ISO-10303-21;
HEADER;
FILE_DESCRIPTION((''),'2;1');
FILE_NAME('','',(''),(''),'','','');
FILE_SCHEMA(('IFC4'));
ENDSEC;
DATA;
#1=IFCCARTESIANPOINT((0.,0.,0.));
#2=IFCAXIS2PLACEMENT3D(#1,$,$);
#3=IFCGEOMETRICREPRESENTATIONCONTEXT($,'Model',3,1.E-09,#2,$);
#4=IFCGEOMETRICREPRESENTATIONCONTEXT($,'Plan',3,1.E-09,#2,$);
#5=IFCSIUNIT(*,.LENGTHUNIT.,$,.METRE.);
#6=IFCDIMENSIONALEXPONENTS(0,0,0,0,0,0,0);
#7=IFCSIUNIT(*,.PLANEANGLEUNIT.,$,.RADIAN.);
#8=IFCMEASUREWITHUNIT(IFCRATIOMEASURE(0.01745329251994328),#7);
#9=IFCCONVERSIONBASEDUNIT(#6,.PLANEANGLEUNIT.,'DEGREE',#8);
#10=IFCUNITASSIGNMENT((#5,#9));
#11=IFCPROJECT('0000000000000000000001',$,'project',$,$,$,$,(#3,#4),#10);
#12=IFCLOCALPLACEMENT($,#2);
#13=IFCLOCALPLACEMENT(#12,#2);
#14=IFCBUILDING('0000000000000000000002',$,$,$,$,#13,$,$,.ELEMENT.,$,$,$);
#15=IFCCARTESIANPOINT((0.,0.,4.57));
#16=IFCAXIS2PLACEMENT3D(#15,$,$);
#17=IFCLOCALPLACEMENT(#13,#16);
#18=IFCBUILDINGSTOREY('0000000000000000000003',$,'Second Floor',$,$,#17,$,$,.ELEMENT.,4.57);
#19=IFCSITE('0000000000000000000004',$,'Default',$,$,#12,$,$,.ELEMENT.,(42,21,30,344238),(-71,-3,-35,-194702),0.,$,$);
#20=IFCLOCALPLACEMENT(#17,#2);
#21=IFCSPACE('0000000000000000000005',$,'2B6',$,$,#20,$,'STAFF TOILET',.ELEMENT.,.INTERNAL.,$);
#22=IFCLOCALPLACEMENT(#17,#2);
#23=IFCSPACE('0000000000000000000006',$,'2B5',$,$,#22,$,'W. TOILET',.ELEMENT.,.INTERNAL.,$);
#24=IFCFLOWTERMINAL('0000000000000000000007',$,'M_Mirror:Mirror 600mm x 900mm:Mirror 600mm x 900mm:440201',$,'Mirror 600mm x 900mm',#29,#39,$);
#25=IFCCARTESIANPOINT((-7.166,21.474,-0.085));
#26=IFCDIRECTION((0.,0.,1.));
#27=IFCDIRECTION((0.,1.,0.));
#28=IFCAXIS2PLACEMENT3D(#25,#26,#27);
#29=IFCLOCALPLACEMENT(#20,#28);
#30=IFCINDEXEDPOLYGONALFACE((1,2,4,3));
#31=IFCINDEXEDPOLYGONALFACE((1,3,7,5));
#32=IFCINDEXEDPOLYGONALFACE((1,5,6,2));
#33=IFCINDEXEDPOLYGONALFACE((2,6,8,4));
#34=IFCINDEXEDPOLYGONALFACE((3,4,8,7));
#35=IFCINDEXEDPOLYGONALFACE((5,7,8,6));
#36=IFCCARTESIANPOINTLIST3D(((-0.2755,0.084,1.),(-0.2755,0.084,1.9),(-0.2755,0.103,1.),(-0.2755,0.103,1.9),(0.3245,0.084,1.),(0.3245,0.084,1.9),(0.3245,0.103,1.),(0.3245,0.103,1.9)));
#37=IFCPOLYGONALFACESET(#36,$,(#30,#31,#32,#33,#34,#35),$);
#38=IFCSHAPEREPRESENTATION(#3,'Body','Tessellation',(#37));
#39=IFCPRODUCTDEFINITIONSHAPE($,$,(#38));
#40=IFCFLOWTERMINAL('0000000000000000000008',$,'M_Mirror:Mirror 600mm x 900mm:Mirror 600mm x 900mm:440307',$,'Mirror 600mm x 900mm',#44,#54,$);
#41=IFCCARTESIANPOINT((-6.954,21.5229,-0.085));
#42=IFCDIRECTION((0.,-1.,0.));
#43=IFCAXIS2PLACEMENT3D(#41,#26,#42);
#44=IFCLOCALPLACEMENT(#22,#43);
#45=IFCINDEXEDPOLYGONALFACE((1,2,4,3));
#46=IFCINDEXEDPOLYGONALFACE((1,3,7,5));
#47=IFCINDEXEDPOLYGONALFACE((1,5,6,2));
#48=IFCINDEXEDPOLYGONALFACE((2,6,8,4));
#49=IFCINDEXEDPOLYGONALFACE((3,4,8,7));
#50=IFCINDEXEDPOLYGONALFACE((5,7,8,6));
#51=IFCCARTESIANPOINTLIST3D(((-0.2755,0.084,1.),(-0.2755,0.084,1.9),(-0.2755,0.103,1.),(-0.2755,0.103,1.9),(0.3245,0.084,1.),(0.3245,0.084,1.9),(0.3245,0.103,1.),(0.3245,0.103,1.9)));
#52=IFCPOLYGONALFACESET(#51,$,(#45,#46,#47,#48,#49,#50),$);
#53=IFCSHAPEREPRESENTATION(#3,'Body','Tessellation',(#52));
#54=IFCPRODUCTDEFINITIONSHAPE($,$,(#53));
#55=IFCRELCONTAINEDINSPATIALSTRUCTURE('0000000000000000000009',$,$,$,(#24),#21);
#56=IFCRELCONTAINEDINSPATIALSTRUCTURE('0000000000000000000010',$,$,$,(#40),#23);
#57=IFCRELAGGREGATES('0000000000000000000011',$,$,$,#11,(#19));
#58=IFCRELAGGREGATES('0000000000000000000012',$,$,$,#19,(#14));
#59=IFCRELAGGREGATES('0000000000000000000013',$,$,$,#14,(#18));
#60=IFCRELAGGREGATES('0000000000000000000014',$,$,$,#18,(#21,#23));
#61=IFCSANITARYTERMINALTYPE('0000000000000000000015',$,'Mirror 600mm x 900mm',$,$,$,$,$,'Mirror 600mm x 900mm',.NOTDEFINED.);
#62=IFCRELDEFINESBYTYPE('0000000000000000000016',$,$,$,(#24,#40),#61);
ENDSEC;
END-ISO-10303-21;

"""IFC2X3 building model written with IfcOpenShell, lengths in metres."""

from ifc_helpers import new_model, entity, si_unit, converted_unit, frame, origin, origin_2d_with_axis, place, context, project, spatial, rectangle, extrude, source, transform, mapped, type_object, type_shapes, element, save


model = new_model("IFC2X3")

# Units and contexts
model_context = context("Model", 3, precision=1e-09, world=origin())
plan_context = context("Plan", 3, precision=1e-09, world=origin())
ifc_project = project(units=[si_unit("LENGTHUNIT", "METRE"), converted_unit("PLANEANGLEUNIT", "DEGREE", entity("IfcRatioMeasure", 0.01745329251994328), si_unit("PLANEANGLEUNIT", "RADIAN"), dimensions=[0, 0, 0, 0, 0, 0, 0])], contexts=[model_context, plan_context])

# Site, building, storey
site_placement = place(None, origin())
site = spatial("IfcSite", under=ifc_project, at=site_placement, Name="Default", CompositionType="ELEMENT", RefLatitude=(42, 21, 30, 344238), RefLongitude=(-71, -3, -35, -194702), RefElevation=0.0)
building_placement = place(site_placement, origin())
building = spatial("IfcBuilding", under=site, at=building_placement, CompositionType="ELEMENT")
storey_placement = place(building_placement, frame((0.0, 0.0, 4.57)))
storey = spatial("IfcBuildingStorey", under=building, at=storey_placement, Name="Second Floor", CompositionType="ELEMENT", Elevation=4.57)

# Shared definitions
space_1_placement = place(storey_placement, origin())
space_1 = spatial("IfcSpace", under=storey, at=space_1_placement, Name="2B6", LongName="STAFF TOILET", CompositionType="ELEMENT", InteriorOrExteriorSpace="INTERNAL")

# Flow terminal
sanitary_terminal_type = type_object("IfcSanitaryTerminalType", Name="Mirror 600mm x 900mm", ElementType="Mirror 600mm x 900mm", PredefinedType="NOTDEFINED")
shared_shape_1 = source(origin(), model_context, "Body", "SweptSolid", [
    extrude(rectangle(XDim=0.0191, YDim=0.6, at=origin_2d_with_axis()), frame((0.0245, 0.0935, 1.0), z_axis=(0.0, 0.0, 1.0), x_axis=(0.0, -1.0, 0.0)), (0.0, 0.0, 1.0), 0.9),
])
type_shapes(sanitary_terminal_type, [shared_shape_1])
flow_terminal_1_placement = place(space_1_placement, frame((-7.166, 21.474, -0.085), z_axis=(0.0, 0.0, 1.0), x_axis=(0.0, 1.0, 0.0)))
element("IfcFlowTerminal", 1, at=flow_terminal_1_placement, inside=space_1, type_object=sanitary_terminal_type, Name="M_Mirror:Mirror 600mm x 900mm:Mirror 600mm x 900mm:440201", ObjectType="Mirror 600mm x 900mm", context=model_context, shape_type="MappedRepresentation", body=[
    mapped(shared_shape_1, transform((0.0, 0.0, 0.0), scale=1.0)),
])

# Shared definitions
space_2_placement = place(storey_placement, origin())
space_2 = spatial("IfcSpace", under=storey, at=space_2_placement, Name="2B5", LongName="W. TOILET", CompositionType="ELEMENT", InteriorOrExteriorSpace="INTERNAL")

# Flow terminal
flow_terminal_2_placement = place(space_2_placement, frame((-6.954, 21.5229, -0.085), z_axis=(0.0, 0.0, 1.0), x_axis=(0.0, -1.0, 0.0)))
element("IfcFlowTerminal", 2, at=flow_terminal_2_placement, inside=space_2, type_object=sanitary_terminal_type, Name="M_Mirror:Mirror 600mm x 900mm:Mirror 600mm x 900mm:440307", ObjectType="Mirror 600mm x 900mm", context=model_context, shape_type="MappedRepresentation", body=[
    mapped(shared_shape_1, transform((0.0, 0.0, 0.0), scale=1.0)),
])

save(model, "model.ifc")
